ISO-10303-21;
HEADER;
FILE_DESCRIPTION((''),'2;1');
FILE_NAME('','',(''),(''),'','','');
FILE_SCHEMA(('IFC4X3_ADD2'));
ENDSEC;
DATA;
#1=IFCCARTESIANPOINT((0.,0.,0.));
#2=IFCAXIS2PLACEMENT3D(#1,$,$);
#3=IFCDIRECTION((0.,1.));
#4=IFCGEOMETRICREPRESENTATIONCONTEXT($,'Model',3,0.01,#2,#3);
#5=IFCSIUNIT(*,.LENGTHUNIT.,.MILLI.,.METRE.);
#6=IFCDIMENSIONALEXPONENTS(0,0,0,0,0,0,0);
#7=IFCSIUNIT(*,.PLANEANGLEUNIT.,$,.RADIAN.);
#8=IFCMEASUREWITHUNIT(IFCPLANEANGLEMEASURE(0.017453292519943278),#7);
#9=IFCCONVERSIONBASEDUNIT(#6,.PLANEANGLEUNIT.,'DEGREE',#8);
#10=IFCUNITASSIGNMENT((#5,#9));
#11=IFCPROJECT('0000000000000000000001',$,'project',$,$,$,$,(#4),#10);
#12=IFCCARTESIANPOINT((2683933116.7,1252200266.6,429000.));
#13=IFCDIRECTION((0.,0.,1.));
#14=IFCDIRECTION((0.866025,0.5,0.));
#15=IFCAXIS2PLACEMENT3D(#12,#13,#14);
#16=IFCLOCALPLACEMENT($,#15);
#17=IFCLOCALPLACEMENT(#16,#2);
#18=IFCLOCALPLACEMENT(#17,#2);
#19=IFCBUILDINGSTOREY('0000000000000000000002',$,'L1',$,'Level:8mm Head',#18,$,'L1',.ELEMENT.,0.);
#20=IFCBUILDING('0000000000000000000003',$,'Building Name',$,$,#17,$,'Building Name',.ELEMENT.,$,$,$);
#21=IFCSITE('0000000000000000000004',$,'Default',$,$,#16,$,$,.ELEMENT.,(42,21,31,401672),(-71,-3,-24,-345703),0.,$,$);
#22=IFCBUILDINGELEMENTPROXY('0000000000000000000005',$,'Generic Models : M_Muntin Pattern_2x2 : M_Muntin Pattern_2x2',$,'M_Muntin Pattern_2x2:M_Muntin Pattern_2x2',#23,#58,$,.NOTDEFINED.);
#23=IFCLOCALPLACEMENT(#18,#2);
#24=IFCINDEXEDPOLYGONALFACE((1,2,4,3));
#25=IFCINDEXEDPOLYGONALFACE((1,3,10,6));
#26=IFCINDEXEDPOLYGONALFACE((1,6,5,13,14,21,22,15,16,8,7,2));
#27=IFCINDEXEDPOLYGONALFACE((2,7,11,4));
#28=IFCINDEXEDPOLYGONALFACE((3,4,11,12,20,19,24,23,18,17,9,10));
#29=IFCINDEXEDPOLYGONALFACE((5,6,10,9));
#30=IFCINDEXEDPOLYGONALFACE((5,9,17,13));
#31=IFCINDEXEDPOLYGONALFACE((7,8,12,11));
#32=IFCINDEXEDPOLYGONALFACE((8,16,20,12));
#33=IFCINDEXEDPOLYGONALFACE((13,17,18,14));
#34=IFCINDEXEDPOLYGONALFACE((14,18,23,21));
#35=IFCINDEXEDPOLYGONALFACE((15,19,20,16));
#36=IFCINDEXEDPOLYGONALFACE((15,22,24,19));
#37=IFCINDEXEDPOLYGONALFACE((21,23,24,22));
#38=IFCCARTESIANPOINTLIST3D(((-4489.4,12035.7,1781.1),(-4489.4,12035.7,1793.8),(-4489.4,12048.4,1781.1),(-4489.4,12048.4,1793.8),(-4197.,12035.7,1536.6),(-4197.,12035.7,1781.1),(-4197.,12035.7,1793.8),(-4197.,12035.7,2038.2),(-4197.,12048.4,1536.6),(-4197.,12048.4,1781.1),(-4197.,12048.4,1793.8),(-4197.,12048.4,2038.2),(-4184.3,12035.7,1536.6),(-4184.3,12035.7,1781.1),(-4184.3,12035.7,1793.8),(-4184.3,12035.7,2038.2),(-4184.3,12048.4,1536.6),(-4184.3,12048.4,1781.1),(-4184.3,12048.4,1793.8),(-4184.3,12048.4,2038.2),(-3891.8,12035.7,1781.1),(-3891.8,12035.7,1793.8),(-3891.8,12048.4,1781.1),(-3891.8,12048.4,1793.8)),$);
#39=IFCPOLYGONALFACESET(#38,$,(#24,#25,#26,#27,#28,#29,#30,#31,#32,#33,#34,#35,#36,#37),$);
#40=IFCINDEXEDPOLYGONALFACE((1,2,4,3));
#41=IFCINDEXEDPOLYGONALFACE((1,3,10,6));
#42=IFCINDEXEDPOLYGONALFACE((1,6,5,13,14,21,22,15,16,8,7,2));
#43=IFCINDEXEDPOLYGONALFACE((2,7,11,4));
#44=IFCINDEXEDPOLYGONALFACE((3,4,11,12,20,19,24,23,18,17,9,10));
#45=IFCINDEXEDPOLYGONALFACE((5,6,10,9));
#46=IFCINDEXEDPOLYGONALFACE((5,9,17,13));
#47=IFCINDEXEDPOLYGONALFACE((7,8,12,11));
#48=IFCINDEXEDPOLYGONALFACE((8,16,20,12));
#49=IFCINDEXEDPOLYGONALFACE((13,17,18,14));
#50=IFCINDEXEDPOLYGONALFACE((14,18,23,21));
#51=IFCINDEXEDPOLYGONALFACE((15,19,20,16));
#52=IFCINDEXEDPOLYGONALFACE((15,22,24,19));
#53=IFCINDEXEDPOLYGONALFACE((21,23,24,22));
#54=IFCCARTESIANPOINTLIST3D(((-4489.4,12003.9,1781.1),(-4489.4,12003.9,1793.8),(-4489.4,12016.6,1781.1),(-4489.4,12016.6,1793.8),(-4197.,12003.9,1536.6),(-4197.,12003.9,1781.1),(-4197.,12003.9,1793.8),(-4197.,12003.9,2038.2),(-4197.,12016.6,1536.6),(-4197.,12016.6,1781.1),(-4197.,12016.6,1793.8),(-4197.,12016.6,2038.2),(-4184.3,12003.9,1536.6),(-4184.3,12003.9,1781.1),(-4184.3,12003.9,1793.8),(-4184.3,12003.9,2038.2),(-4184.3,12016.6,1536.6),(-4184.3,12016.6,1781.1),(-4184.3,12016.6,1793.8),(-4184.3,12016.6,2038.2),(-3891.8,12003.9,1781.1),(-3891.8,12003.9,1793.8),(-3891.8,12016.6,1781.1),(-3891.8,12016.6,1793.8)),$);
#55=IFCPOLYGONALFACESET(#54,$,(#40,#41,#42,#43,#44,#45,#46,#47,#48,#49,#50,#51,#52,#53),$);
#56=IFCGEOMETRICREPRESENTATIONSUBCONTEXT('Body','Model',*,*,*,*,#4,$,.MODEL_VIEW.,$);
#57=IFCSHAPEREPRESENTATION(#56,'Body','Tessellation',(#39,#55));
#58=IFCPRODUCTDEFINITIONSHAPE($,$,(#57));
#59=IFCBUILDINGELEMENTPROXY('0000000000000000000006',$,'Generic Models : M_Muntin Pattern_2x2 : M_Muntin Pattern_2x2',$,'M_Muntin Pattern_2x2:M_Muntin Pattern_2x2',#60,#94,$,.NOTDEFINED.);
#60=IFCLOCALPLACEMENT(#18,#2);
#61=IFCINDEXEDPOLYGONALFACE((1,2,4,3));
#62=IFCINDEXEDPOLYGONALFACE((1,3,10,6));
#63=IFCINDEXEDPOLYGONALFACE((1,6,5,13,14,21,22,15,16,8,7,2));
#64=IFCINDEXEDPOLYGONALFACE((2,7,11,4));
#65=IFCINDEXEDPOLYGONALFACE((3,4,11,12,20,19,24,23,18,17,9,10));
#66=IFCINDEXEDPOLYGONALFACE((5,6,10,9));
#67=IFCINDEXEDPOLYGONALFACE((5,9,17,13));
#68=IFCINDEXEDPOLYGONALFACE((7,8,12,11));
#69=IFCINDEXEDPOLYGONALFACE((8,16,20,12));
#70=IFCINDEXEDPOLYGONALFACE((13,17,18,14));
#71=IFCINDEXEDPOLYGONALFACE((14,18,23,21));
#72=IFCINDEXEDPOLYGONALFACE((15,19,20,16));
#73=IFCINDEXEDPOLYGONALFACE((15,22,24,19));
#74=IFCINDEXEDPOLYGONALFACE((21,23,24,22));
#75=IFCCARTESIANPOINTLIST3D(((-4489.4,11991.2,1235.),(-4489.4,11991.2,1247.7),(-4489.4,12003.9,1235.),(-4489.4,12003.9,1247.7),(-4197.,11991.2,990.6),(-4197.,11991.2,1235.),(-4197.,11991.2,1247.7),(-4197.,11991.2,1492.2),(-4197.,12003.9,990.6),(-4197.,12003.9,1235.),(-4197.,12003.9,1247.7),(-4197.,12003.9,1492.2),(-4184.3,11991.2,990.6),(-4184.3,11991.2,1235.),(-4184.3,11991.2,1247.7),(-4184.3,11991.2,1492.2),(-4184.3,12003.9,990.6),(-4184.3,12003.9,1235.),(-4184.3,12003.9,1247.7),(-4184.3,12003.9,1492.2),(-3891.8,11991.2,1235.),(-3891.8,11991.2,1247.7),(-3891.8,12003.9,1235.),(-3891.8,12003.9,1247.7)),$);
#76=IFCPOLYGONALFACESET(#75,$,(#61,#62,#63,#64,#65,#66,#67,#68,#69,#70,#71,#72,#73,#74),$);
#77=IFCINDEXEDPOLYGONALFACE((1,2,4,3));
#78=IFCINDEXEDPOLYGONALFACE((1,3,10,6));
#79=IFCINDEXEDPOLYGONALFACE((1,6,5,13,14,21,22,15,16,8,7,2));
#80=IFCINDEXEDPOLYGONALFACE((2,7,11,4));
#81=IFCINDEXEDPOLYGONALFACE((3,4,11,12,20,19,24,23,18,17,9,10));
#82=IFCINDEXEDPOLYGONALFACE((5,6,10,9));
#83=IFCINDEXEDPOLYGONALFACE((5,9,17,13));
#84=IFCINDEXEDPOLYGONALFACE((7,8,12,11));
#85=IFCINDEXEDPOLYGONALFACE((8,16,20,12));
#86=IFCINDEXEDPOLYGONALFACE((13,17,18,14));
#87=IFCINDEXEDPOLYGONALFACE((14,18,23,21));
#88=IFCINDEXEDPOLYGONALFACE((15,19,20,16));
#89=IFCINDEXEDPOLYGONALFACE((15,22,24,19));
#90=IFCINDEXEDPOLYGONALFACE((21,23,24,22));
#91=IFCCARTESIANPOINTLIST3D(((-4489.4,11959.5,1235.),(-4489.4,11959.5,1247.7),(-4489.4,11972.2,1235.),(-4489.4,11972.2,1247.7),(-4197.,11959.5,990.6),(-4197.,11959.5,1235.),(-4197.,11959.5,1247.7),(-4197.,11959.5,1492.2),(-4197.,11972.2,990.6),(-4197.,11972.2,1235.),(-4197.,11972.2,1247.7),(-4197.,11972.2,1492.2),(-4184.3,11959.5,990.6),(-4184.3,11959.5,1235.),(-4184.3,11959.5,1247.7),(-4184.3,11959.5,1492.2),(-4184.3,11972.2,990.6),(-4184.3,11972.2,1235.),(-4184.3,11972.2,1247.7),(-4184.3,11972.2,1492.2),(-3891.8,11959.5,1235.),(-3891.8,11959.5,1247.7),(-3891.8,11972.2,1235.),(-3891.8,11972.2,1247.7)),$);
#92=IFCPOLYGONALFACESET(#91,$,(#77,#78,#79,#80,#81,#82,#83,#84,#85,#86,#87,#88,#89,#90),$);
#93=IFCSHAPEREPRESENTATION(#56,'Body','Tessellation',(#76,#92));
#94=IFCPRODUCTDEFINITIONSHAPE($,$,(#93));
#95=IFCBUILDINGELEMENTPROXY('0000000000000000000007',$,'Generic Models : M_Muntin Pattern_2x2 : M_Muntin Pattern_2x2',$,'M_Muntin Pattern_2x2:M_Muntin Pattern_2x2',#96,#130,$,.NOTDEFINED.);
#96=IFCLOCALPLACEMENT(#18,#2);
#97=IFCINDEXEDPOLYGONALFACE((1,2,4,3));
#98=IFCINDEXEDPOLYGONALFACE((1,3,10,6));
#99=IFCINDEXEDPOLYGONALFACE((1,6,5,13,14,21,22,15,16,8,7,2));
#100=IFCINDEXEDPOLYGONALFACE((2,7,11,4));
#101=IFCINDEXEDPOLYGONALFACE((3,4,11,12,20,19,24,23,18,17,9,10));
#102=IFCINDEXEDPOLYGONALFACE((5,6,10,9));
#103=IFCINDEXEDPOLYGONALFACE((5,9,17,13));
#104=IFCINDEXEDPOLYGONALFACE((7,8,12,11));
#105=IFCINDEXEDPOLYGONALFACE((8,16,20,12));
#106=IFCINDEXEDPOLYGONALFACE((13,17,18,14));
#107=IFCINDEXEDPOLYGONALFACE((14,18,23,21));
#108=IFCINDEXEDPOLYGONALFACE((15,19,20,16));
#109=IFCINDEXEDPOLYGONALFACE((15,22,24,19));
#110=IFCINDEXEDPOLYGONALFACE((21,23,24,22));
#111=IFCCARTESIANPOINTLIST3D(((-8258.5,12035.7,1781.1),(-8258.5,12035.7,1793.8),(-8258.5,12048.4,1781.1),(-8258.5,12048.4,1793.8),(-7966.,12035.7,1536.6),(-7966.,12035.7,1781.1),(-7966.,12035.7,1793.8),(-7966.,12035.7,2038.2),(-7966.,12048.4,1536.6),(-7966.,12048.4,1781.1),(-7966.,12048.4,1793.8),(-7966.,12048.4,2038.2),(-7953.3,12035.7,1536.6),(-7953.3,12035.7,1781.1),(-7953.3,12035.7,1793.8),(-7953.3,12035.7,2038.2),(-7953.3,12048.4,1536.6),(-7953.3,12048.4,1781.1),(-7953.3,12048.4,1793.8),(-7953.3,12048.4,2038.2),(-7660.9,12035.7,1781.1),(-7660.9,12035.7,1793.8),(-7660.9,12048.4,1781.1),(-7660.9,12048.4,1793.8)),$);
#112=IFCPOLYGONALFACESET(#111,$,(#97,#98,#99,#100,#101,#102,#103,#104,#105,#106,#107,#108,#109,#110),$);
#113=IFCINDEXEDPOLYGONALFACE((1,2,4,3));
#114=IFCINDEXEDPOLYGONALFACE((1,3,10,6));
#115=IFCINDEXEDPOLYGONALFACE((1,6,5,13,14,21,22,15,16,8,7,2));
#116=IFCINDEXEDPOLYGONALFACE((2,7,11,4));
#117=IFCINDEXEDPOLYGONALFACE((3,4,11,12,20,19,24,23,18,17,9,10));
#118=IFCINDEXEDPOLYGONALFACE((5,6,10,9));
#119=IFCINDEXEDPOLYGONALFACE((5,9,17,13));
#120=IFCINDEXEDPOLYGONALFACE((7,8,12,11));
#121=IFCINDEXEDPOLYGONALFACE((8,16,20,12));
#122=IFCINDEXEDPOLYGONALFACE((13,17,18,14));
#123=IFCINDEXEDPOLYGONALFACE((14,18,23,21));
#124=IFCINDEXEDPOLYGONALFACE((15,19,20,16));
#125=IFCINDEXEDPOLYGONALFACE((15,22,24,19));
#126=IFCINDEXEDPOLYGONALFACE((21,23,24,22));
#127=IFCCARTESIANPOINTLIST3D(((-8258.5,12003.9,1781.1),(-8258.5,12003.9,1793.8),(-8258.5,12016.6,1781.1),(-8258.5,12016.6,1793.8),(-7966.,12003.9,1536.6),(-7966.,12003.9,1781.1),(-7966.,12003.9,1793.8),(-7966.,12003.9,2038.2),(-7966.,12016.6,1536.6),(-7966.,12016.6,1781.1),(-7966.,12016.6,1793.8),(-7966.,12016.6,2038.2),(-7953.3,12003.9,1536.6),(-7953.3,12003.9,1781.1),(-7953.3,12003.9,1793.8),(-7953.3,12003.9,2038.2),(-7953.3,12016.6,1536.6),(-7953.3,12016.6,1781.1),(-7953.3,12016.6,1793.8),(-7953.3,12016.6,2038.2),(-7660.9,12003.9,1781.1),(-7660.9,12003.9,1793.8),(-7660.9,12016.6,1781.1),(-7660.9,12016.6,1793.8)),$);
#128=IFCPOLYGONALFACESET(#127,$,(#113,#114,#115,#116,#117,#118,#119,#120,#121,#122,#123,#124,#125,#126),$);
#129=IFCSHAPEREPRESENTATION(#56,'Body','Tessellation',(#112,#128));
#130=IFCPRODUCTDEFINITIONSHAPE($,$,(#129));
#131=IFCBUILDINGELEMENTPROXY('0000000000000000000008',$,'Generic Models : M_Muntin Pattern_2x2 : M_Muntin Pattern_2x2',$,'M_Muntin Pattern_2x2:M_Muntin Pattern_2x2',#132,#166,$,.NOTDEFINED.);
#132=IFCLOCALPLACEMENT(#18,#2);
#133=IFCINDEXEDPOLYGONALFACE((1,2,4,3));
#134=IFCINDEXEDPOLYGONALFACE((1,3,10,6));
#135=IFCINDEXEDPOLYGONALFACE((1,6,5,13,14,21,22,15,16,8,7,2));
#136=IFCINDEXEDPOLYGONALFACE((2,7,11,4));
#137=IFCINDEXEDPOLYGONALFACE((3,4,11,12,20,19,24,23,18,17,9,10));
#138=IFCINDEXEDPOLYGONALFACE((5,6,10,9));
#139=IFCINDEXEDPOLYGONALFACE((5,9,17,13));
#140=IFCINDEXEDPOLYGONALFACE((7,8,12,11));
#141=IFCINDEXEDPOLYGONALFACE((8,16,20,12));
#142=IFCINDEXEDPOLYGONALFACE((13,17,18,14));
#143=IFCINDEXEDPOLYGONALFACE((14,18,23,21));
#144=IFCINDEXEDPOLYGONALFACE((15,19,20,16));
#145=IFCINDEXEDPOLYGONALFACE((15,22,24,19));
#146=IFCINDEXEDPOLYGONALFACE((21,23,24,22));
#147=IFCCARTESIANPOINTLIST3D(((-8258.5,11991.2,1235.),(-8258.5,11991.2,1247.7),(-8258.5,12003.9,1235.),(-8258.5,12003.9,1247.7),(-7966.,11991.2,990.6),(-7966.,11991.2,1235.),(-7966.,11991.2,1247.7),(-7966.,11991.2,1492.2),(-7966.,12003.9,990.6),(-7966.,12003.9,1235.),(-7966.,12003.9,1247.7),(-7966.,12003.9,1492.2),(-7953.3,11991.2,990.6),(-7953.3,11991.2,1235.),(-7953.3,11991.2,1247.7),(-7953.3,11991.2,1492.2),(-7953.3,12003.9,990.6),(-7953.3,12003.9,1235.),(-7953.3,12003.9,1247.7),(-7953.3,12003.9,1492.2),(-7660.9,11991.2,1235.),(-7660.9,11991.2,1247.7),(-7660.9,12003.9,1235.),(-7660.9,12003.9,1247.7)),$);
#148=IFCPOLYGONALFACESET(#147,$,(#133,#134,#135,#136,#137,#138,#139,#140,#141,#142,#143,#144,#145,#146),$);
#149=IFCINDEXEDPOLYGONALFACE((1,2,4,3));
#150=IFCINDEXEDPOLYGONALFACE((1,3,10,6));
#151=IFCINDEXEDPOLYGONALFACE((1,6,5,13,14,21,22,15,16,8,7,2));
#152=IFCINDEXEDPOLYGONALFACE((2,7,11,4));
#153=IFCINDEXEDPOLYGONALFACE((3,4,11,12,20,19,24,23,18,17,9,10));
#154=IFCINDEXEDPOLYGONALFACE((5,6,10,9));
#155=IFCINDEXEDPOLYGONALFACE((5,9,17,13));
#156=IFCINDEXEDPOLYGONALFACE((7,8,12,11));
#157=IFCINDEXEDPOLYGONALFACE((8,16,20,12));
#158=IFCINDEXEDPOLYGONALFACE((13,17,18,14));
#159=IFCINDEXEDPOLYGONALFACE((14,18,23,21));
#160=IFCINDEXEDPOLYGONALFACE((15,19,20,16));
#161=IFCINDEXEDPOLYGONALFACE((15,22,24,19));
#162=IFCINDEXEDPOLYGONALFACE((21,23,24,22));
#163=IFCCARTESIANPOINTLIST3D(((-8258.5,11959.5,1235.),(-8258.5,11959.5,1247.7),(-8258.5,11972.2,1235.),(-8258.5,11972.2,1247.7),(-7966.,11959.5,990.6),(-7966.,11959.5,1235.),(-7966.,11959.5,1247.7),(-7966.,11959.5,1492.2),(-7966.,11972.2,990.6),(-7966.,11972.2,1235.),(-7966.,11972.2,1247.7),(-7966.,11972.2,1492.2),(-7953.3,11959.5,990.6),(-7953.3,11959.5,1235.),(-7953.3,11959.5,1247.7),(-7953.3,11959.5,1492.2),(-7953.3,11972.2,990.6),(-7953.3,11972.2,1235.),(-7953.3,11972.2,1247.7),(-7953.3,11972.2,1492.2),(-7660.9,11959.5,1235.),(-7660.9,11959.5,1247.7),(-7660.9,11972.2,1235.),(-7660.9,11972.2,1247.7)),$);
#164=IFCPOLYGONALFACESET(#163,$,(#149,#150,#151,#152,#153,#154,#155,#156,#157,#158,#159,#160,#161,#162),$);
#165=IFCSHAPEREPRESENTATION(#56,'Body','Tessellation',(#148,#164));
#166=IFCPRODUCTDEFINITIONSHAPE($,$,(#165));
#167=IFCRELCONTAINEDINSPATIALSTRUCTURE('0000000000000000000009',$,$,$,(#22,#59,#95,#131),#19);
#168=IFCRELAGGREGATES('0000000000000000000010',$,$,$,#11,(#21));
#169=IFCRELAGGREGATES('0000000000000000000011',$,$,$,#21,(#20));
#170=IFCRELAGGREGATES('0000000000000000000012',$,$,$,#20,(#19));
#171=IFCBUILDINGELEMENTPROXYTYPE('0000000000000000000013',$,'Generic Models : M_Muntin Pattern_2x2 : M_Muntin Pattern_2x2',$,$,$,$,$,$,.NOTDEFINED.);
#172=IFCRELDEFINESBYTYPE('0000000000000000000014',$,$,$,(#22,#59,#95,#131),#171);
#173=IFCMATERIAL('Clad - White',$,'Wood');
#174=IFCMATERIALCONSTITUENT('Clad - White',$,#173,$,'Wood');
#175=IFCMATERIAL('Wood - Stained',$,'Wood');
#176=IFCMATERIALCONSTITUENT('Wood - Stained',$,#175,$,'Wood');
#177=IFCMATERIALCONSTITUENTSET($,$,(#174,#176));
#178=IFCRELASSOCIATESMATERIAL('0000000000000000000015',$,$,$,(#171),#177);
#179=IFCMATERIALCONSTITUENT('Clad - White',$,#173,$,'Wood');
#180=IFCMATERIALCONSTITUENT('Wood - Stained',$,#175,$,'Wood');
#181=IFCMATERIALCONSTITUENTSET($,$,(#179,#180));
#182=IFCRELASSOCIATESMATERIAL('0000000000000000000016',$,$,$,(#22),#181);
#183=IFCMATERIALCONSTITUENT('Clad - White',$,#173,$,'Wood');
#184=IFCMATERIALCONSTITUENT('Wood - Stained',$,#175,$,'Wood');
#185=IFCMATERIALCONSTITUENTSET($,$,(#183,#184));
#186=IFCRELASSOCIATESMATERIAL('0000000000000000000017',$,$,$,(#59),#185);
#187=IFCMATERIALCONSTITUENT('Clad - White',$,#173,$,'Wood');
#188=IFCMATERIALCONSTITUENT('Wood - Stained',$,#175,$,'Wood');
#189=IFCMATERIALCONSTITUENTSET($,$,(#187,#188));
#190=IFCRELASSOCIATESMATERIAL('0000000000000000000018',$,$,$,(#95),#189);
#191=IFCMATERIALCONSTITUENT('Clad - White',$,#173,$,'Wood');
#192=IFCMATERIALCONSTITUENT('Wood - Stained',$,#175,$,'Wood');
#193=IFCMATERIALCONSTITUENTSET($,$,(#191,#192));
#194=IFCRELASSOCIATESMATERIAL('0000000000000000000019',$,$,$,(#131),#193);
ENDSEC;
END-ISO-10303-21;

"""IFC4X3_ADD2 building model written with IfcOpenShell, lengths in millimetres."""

from ifc_helpers import new_model, entity, si_unit, converted_unit, direction, frame, origin, place, context, subcontext, project, spatial, polyline, outline, extrude, source, transform, mapped, material, constituent, constituent_set, type_object, type_shapes, element, save


model = new_model("IFC4X3_ADD2")

# Units and contexts
model_context = context("Model", 3, precision=0.01, world=origin(), true_north=direction((0.0, 1.0)))
body_context = subcontext(model_context, "Body", "Model", "MODEL_VIEW")
ifc_project = project(units=[si_unit("LENGTHUNIT", "METRE", prefix="MILLI"), converted_unit("PLANEANGLEUNIT", "DEGREE", entity("IfcPlaneAngleMeasure", 0.017453292519943278), si_unit("PLANEANGLEUNIT", "RADIAN"), dimensions=[0, 0, 0, 0, 0, 0, 0])], contexts=[model_context])

# Site, building, storey
site_placement = place(None, frame((2683933116.7, 1252200266.6, 429000.0), z_axis=(0.0, 0.0, 1.0), x_axis=(0.866025, 0.5, 0.0)))
site = spatial("IfcSite", under=ifc_project, at=site_placement, Name="Default", CompositionType="ELEMENT", RefLatitude=(42, 21, 31, 401672), RefLongitude=(-71, -3, -24, -345703), RefElevation=0.0)
building_placement = place(site_placement, origin())
building = spatial("IfcBuilding", under=site, at=building_placement, Name="Building Name", LongName="Building Name", CompositionType="ELEMENT")
storey_placement = place(building_placement, origin())
storey = spatial("IfcBuildingStorey", under=building, at=storey_placement, Name="L1", ObjectType="Level:8mm Head", LongName="L1", CompositionType="ELEMENT", Elevation=0.0)

# Shared definitions
ifc_material_1 = material(Name="Wood - Stained", Category="Wood")

# Building element proxies
ifc_material_2 = material(Name="Clad - White", Category="Wood")
ifc_constituent_1 = constituent(ifc_material_2, Name="Clad - White", Category="Wood")
ifc_constituent_2 = constituent(ifc_material_1, Name="Wood - Stained", Category="Wood")
ifc_constituent_set_1 = constituent_set(constituents=[ifc_constituent_1, ifc_constituent_2])
building_element_proxy_type_1 = type_object("IfcBuildingElementProxyType", Name="Generic Models : M_Muntin Pattern_2x2 : M_Muntin Pattern_2x2", PredefinedType="NOTDEFINED", material=ifc_constituent_set_1)
shared_shape_1 = source(origin(), body_context, "Body", "SweptSolid", [
    extrude(outline(polyline([(6.4, -6.4), (250.8, -6.4), (250.8, 6.3), (6.4, 6.3), (6.4, 298.8), (-6.3, 298.8), (-6.3, 6.3), (-250.8, 6.3), (-250.8, -6.4), (-6.3, -6.4), (-6.3, -298.8), (6.4, -298.8), (6.4, -6.4)])), frame((0.0, 9.5, 250.8), z_axis=(0.0, 1.0, 0.0), x_axis=(0.0, 0.0, 1.0)), (0.0, 0.0, 1.0), 12.7),
    extrude(outline(polyline([(6.4, -6.4), (250.8, -6.4), (250.8, 6.3), (6.4, 6.3), (6.4, 298.8), (-6.3, 298.8), (-6.3, 6.3), (-250.8, 6.3), (-250.8, -6.4), (-6.3, -6.4), (-6.3, -298.8), (6.4, -298.8), (6.4, -6.4)])), frame((0.0, -22.2, 250.8), z_axis=(0.0, 1.0, 0.0), x_axis=(0.0, 0.0, 1.0)), (0.0, 0.0, 1.0), 12.7),
])
type_shapes(building_element_proxy_type_1, [shared_shape_1])
ifc_constituent_3 = constituent(ifc_material_2, Name="Clad - White", Category="Wood")
ifc_constituent_4 = constituent(ifc_material_1, Name="Wood - Stained", Category="Wood")
ifc_constituent_set_2 = constituent_set(constituents=[ifc_constituent_3, ifc_constituent_4])
proxy_1_placement = place(storey_placement, frame((-4190.6, 12026.1, 1536.6)))
element("IfcBuildingElementProxy", 1, at=proxy_1_placement, inside=storey, type_object=building_element_proxy_type_1, material=ifc_constituent_set_2, Name="Generic Models : M_Muntin Pattern_2x2 : M_Muntin Pattern_2x2", ObjectType="M_Muntin Pattern_2x2:M_Muntin Pattern_2x2", PredefinedType="NOTDEFINED", context=body_context, shape_type="MappedRepresentation", body=[
    mapped(shared_shape_1, transform((0.0, 0.0, 0.0), scale=1.0)),
])
ifc_constituent_5 = constituent(ifc_material_2, Name="Clad - White", Category="Wood")
ifc_constituent_6 = constituent(ifc_material_1, Name="Wood - Stained", Category="Wood")
ifc_constituent_set_3 = constituent_set(constituents=[ifc_constituent_5, ifc_constituent_6])
proxy_2_placement = place(storey_placement, frame((-4190.6, 11981.7, 990.6)))
element("IfcBuildingElementProxy", 2, at=proxy_2_placement, inside=storey, type_object=building_element_proxy_type_1, material=ifc_constituent_set_3, Name="Generic Models : M_Muntin Pattern_2x2 : M_Muntin Pattern_2x2", ObjectType="M_Muntin Pattern_2x2:M_Muntin Pattern_2x2", PredefinedType="NOTDEFINED", context=body_context, shape_type="MappedRepresentation", body=[
    mapped(shared_shape_1, transform((0.0, 0.0, 0.0), scale=1.0)),
])
ifc_constituent_7 = constituent(ifc_material_2, Name="Clad - White", Category="Wood")
ifc_constituent_8 = constituent(ifc_material_1, Name="Wood - Stained", Category="Wood")
ifc_constituent_set_4 = constituent_set(constituents=[ifc_constituent_7, ifc_constituent_8])
proxy_3_placement = place(storey_placement, frame((-7959.7, 12026.1, 1536.6)))
element("IfcBuildingElementProxy", 3, at=proxy_3_placement, inside=storey, type_object=building_element_proxy_type_1, material=ifc_constituent_set_4, Name="Generic Models : M_Muntin Pattern_2x2 : M_Muntin Pattern_2x2", ObjectType="M_Muntin Pattern_2x2:M_Muntin Pattern_2x2", PredefinedType="NOTDEFINED", context=body_context, shape_type="MappedRepresentation", body=[
    mapped(shared_shape_1, transform((0.0, 0.0, 0.0), scale=1.0)),
])
ifc_constituent_9 = constituent(ifc_material_2, Name="Clad - White", Category="Wood")
ifc_constituent_10 = constituent(ifc_material_1, Name="Wood - Stained", Category="Wood")
ifc_constituent_set_5 = constituent_set(constituents=[ifc_constituent_9, ifc_constituent_10])
proxy_4_placement = place(storey_placement, frame((-7959.7, 11981.7, 990.6)))
element("IfcBuildingElementProxy", 4, at=proxy_4_placement, inside=storey, type_object=building_element_proxy_type_1, material=ifc_constituent_set_5, Name="Generic Models : M_Muntin Pattern_2x2 : M_Muntin Pattern_2x2", ObjectType="M_Muntin Pattern_2x2:M_Muntin Pattern_2x2", PredefinedType="NOTDEFINED", context=body_context, shape_type="MappedRepresentation", body=[
    mapped(shared_shape_1, transform((0.0, 0.0, 0.0), scale=1.0)),
])

save(model, "model.ifc")
